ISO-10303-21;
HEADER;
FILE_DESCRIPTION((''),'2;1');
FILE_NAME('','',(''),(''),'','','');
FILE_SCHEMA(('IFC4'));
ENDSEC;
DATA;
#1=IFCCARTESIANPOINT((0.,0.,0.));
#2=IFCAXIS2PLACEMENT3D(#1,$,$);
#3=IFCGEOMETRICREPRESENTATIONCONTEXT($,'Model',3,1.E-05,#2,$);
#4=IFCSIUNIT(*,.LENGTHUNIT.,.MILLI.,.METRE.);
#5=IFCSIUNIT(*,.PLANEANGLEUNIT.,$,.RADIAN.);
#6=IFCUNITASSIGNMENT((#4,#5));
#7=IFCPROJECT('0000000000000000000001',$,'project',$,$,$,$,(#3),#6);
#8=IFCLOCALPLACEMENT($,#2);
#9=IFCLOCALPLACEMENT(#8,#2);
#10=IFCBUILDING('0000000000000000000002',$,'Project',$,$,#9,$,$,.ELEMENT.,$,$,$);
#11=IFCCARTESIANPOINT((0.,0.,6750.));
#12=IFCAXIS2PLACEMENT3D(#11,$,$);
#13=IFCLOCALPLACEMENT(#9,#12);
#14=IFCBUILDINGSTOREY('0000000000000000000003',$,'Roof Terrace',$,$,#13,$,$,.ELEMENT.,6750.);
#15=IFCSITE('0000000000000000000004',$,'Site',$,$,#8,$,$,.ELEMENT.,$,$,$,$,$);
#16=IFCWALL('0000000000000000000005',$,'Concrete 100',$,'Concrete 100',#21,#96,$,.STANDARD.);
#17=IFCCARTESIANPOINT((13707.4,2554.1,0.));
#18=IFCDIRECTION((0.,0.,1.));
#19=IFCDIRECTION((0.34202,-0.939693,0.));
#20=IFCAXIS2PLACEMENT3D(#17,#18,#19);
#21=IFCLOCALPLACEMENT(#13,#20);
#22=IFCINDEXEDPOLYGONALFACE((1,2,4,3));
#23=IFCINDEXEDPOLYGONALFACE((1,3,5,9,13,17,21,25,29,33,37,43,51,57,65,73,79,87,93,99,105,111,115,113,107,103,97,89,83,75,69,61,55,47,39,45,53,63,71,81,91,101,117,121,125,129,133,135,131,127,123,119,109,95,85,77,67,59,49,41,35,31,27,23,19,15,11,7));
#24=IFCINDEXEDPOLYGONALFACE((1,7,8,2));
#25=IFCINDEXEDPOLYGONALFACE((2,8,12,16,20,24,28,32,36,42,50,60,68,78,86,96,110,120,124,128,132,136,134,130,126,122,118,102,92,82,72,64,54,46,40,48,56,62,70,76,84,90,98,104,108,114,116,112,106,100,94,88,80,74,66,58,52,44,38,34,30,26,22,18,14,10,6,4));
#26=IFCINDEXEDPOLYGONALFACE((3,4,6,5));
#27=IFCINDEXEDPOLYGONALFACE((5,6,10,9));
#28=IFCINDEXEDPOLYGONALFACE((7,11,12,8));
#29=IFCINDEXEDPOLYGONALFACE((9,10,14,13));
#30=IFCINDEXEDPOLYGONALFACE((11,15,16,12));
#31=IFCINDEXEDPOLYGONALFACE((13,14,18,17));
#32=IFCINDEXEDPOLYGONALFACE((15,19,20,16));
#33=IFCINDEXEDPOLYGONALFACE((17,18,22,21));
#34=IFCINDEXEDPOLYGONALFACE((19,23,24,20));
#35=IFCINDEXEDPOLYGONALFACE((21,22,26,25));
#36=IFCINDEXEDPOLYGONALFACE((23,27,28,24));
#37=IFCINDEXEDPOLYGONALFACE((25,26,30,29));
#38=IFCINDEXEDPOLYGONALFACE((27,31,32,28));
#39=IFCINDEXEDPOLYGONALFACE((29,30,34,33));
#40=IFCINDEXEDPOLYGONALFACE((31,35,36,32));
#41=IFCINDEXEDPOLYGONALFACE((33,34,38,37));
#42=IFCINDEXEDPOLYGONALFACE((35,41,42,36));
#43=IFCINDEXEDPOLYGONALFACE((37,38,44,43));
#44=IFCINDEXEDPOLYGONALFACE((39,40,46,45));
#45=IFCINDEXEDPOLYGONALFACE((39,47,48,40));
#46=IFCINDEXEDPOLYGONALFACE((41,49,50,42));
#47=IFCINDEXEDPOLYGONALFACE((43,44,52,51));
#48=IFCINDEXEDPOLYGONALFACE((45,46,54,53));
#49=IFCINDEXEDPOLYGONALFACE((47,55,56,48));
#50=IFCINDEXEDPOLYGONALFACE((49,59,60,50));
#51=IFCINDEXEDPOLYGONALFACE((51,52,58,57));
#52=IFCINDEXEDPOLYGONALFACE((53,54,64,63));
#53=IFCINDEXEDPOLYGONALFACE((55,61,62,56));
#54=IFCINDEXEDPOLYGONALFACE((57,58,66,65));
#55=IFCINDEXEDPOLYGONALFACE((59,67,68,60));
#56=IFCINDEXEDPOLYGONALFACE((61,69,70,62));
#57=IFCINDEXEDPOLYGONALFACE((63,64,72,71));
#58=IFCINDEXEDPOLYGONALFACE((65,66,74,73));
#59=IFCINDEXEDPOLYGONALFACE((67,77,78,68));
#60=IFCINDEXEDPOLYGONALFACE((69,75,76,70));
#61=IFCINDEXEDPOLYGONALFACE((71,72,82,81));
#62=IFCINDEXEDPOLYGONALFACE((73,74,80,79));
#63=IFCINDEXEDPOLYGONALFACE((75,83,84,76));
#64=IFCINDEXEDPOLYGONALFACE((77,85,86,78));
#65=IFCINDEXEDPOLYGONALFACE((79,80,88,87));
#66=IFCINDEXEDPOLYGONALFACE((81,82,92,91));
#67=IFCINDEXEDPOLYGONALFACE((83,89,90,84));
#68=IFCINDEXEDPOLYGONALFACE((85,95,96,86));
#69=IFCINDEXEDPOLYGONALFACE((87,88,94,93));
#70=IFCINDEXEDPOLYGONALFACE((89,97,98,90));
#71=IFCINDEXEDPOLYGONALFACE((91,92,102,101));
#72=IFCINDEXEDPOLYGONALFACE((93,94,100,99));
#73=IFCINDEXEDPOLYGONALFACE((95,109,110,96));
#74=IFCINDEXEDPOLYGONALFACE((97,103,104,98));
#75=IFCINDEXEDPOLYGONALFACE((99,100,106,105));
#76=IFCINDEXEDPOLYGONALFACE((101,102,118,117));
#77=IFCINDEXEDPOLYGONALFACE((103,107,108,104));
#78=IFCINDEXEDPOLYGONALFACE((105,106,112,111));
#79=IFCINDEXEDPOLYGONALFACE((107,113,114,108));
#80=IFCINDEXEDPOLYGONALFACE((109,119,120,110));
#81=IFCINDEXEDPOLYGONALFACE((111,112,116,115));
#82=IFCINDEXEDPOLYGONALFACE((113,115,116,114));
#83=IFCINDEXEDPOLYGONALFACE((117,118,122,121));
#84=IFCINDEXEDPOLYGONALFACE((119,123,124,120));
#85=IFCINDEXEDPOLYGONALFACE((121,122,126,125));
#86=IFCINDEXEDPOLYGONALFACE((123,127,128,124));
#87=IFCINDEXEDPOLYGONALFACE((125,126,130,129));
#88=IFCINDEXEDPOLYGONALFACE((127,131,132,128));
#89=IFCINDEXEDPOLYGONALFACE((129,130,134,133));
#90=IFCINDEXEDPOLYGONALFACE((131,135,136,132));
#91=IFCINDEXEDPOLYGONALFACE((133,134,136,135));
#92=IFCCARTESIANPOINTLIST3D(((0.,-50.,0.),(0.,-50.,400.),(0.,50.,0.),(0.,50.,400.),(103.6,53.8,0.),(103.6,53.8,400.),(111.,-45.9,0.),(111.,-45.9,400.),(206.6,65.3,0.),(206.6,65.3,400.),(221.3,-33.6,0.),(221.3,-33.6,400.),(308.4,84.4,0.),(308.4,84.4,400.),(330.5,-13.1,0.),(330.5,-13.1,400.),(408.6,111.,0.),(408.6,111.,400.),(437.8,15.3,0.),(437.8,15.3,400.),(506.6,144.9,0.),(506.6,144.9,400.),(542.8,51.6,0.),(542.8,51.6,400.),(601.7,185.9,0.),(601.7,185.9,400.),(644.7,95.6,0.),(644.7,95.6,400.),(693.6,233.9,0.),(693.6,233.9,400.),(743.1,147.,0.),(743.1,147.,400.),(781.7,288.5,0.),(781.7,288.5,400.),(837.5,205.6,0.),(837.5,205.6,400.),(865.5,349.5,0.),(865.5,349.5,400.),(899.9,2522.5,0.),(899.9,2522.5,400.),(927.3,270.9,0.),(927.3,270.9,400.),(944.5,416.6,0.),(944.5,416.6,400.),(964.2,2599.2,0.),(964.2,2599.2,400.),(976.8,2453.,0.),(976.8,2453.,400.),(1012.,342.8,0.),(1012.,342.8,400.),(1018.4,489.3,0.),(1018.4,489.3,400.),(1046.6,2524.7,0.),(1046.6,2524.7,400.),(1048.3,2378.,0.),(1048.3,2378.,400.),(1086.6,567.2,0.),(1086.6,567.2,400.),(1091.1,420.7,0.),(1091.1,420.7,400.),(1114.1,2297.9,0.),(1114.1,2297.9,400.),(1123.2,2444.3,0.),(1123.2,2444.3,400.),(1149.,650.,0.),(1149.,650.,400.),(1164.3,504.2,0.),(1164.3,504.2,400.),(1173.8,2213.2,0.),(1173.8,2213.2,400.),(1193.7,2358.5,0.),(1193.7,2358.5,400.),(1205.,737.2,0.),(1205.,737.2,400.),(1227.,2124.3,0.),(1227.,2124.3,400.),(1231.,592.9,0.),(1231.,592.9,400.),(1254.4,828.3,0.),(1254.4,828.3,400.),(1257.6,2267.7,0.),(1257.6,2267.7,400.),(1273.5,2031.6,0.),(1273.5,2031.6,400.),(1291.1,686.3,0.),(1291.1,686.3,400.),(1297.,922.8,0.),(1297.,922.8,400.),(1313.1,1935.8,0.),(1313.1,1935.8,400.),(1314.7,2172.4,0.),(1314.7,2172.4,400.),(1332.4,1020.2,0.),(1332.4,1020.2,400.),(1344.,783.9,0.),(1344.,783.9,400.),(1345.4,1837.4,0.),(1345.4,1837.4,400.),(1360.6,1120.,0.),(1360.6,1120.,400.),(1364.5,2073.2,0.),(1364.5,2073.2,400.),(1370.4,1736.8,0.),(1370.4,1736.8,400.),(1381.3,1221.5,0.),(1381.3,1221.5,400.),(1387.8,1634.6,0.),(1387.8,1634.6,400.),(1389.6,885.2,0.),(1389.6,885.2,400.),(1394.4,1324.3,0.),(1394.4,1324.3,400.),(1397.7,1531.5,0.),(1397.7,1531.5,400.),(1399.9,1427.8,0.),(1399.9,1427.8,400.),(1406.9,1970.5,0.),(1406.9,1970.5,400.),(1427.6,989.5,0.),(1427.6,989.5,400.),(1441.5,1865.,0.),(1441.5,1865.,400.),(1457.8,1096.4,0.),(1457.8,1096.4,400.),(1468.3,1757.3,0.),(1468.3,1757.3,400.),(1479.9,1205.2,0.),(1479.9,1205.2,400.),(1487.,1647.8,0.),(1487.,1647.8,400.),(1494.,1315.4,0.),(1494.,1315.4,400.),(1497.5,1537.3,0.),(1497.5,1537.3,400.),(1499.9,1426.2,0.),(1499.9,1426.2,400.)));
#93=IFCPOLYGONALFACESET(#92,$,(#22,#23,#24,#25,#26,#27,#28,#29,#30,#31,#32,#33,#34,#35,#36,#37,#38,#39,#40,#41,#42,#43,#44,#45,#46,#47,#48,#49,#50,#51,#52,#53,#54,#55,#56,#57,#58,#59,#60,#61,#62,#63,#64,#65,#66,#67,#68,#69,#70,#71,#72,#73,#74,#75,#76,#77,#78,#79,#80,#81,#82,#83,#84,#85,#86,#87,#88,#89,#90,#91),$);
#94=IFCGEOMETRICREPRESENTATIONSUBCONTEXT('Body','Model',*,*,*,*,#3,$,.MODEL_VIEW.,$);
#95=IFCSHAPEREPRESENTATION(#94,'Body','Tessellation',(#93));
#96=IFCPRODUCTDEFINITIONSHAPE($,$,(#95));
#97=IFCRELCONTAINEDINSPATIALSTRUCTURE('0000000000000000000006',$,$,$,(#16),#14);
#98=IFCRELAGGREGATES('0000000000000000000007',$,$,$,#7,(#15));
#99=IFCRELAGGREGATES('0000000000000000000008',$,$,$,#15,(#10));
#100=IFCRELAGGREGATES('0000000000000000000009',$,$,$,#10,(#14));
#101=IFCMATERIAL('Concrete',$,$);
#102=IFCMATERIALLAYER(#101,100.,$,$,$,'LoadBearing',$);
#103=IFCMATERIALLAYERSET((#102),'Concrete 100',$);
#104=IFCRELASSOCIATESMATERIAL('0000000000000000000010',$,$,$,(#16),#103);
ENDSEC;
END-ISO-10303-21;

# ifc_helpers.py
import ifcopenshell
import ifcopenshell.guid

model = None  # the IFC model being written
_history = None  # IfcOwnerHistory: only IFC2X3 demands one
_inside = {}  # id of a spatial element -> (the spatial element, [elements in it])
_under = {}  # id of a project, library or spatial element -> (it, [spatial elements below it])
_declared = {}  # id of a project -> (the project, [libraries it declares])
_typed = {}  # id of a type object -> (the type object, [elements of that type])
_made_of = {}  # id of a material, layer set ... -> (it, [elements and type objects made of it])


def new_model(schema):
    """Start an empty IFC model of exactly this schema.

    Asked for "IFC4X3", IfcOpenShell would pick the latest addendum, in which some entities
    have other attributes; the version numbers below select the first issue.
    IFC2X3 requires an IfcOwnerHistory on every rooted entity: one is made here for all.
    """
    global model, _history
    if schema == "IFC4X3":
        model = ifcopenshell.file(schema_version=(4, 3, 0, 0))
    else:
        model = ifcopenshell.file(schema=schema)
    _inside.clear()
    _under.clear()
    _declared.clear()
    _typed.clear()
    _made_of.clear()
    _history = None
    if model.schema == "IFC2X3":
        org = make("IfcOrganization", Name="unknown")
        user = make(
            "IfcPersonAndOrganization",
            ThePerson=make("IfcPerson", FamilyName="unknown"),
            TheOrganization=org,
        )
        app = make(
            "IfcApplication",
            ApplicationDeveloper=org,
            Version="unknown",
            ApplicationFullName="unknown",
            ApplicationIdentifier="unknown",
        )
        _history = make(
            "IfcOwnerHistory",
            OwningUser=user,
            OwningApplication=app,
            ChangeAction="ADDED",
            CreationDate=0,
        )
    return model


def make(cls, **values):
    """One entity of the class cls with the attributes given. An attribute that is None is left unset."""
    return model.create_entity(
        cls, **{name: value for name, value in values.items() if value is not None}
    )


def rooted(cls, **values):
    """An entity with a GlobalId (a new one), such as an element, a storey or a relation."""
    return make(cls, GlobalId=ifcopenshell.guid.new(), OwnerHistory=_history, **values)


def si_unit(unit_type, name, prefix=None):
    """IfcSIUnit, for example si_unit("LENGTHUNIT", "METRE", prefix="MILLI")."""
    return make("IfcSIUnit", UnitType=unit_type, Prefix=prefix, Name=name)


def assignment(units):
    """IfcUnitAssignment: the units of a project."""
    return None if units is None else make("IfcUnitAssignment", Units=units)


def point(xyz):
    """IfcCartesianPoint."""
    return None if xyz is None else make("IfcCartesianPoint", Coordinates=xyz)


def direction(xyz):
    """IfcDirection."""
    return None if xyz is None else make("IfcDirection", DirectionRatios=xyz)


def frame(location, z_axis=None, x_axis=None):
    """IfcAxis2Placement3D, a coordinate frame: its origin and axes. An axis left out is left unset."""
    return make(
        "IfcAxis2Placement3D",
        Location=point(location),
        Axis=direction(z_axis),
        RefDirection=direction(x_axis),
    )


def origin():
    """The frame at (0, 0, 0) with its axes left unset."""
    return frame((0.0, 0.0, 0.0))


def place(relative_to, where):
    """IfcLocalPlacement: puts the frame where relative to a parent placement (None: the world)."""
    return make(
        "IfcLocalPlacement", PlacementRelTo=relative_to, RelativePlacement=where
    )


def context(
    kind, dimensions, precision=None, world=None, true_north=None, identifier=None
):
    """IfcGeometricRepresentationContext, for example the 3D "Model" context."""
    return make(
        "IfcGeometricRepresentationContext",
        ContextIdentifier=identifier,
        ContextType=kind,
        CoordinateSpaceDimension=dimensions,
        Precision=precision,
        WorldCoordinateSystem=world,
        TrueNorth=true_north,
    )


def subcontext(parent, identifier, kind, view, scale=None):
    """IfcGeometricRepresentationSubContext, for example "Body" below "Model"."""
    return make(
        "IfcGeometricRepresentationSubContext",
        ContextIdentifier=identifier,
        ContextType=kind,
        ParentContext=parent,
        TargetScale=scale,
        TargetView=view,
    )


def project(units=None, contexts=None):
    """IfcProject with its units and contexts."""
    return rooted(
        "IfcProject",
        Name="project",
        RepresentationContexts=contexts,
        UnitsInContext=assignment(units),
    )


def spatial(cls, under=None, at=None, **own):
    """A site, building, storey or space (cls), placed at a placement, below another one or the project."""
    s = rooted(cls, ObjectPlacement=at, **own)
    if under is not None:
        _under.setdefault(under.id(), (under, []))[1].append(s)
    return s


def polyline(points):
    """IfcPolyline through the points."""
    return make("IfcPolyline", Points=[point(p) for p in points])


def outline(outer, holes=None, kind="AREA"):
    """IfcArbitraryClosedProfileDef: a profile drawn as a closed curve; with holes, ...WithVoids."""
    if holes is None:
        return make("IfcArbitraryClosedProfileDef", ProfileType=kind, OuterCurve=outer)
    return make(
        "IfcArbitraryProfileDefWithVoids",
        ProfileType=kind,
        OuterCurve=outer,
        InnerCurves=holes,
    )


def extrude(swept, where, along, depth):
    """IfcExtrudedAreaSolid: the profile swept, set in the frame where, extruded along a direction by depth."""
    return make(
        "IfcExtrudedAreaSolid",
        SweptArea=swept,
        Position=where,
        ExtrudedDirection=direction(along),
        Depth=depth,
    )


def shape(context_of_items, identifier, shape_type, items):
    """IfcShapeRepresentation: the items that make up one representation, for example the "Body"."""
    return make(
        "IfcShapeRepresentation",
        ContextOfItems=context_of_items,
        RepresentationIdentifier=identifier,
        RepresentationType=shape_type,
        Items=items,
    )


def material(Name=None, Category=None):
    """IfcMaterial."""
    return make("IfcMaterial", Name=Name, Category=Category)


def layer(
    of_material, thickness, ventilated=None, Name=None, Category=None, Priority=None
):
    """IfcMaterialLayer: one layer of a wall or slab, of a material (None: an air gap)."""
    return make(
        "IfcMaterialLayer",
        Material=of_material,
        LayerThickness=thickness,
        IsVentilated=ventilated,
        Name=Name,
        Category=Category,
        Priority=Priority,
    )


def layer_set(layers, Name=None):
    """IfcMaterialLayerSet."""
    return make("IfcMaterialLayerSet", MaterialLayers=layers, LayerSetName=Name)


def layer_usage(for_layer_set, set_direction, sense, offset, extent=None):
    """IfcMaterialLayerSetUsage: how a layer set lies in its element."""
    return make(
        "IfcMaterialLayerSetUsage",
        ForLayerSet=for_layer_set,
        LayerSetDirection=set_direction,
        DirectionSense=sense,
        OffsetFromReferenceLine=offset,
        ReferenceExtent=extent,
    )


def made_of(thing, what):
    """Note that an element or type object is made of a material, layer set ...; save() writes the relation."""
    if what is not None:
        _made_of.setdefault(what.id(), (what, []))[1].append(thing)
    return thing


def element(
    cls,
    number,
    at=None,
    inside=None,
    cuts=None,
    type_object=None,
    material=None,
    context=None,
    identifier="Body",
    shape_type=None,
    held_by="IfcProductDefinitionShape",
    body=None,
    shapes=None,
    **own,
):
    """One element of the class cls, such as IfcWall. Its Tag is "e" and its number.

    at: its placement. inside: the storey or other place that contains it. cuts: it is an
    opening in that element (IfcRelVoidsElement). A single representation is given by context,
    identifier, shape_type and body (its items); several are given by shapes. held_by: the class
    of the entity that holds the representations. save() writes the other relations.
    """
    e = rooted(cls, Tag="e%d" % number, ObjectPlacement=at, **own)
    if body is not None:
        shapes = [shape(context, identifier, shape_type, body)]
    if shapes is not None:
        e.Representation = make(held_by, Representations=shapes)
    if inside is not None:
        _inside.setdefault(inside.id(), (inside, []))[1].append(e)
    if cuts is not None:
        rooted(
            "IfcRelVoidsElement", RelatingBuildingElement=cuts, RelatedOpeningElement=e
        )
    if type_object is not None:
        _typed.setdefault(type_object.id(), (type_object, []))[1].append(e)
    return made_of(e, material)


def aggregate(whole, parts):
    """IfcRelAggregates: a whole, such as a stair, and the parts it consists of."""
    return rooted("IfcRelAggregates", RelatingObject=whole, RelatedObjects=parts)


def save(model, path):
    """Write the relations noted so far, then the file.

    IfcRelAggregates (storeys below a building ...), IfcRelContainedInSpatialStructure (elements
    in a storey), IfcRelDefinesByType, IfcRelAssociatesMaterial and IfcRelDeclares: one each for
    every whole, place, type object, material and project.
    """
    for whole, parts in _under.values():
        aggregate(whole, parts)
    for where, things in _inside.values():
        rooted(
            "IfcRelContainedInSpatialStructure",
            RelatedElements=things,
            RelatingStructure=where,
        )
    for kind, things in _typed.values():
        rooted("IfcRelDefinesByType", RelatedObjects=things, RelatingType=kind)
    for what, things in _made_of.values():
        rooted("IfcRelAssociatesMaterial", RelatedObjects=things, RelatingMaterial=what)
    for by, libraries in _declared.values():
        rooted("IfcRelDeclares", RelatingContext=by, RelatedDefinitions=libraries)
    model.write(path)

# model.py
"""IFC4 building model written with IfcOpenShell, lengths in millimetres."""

from ifc_helpers import new_model, si_unit, frame, origin, place, context, subcontext, project, spatial, polyline, outline, extrude, material, layer, layer_set, layer_usage, element, save


model = new_model("IFC4")

# Units and contexts
model_context = context("Model", 3, precision=1e-05, world=origin())
body_context = subcontext(model_context, "Body", "Model", "MODEL_VIEW")
ifc_project = project(units=[si_unit("LENGTHUNIT", "METRE", prefix="MILLI"), si_unit("PLANEANGLEUNIT", "RADIAN")], contexts=[model_context])

# Site, building, storey
site_placement = place(None, origin())
site = spatial("IfcSite", under=ifc_project, at=site_placement, Name="Site", CompositionType="ELEMENT")
building_placement = place(site_placement, origin())
building = spatial("IfcBuilding", under=site, at=building_placement, Name="Project", CompositionType="ELEMENT")
storey_placement = place(building_placement, frame((0.0, 0.0, 6750.0)))
storey = spatial("IfcBuildingStorey", under=building, at=storey_placement, Name="Roof Terrace", CompositionType="ELEMENT", Elevation=6750.0)

# Shared definitions
ifc_material = material(Name="Concrete")

# Wall
ifc_layer_1 = layer(ifc_material, 100.0, Category="LoadBearing")
ifc_layer_set_1 = layer_set([ifc_layer_1], Name="Concrete 100")
ifc_layer_usage_1 = layer_usage(ifc_layer_set_1, "AXIS2", "NEGATIVE", 50.0)
wall_1_placement = place(storey_placement, frame((13707.4, 2554.1, 0.0), z_axis=(0.0, 0.0, 1.0), x_axis=(0.34202, -0.939693, 0.0)))
element("IfcWall", 1, at=wall_1_placement, inside=storey, material=ifc_layer_usage_1, Name="Concrete 100", ObjectType="Concrete 100", PredefinedType="STANDARD", context=body_context, shape_type="SweptSolid", body=[
    extrude(outline(polyline([(0.0, -50.0), (0.0, 50.0), (103.6, 53.8), (206.6, 65.3), (308.4, 84.4), (408.6, 111.0), (506.6, 144.9), (601.7, 185.9), (693.6, 233.9), (781.7, 288.5), (865.5, 349.5), (944.5, 416.6), (1018.4, 489.3), (1086.6, 567.2), (1149.0, 650.0), (1205.0, 737.2), (1254.4, 828.3), (1297.0, 922.8), (1332.4, 1020.2), (1360.6, 1120.0), (1381.3, 1221.5), (1394.4, 1324.3), (1399.9, 1427.8), (1397.7, 1531.5), (1387.8, 1634.6), (1370.4, 1736.8), (1345.4, 1837.4), (1313.1, 1935.8), (1273.5, 2031.6), (1227.0, 2124.3), (1173.8, 2213.2), (1114.1, 2297.9), (1048.3, 2378.0), (976.8, 2453.0), (899.9, 2522.5), (964.2, 2599.2), (1046.6, 2524.7), (1123.2, 2444.3), (1193.7, 2358.5), (1257.6, 2267.7), (1314.7, 2172.4), (1364.5, 2073.2), (1406.9, 1970.5), (1441.5, 1865.0), (1468.3, 1757.3), (1487.0, 1647.8), (1497.5, 1537.3), (1499.9, 1426.2), (1494.0, 1315.4), (1479.9, 1205.2), (1457.8, 1096.4), (1427.6, 989.5), (1389.6, 885.2), (1344.0, 783.9), (1291.1, 686.3), (1231.0, 592.9), (1164.3, 504.2), (1091.1, 420.7), (1012.0, 342.8), (927.3, 270.9), (837.5, 205.6), (743.1, 147.0), (644.7, 95.6), (542.8, 51.6), (437.8, 15.3), (330.5, -13.1), (221.3, -33.6), (111.0, -45.9), (0.0, -50.0)])), origin(), (0.0, 0.0, 1.0), 400.0),
])

save(model, "model.ifc")
